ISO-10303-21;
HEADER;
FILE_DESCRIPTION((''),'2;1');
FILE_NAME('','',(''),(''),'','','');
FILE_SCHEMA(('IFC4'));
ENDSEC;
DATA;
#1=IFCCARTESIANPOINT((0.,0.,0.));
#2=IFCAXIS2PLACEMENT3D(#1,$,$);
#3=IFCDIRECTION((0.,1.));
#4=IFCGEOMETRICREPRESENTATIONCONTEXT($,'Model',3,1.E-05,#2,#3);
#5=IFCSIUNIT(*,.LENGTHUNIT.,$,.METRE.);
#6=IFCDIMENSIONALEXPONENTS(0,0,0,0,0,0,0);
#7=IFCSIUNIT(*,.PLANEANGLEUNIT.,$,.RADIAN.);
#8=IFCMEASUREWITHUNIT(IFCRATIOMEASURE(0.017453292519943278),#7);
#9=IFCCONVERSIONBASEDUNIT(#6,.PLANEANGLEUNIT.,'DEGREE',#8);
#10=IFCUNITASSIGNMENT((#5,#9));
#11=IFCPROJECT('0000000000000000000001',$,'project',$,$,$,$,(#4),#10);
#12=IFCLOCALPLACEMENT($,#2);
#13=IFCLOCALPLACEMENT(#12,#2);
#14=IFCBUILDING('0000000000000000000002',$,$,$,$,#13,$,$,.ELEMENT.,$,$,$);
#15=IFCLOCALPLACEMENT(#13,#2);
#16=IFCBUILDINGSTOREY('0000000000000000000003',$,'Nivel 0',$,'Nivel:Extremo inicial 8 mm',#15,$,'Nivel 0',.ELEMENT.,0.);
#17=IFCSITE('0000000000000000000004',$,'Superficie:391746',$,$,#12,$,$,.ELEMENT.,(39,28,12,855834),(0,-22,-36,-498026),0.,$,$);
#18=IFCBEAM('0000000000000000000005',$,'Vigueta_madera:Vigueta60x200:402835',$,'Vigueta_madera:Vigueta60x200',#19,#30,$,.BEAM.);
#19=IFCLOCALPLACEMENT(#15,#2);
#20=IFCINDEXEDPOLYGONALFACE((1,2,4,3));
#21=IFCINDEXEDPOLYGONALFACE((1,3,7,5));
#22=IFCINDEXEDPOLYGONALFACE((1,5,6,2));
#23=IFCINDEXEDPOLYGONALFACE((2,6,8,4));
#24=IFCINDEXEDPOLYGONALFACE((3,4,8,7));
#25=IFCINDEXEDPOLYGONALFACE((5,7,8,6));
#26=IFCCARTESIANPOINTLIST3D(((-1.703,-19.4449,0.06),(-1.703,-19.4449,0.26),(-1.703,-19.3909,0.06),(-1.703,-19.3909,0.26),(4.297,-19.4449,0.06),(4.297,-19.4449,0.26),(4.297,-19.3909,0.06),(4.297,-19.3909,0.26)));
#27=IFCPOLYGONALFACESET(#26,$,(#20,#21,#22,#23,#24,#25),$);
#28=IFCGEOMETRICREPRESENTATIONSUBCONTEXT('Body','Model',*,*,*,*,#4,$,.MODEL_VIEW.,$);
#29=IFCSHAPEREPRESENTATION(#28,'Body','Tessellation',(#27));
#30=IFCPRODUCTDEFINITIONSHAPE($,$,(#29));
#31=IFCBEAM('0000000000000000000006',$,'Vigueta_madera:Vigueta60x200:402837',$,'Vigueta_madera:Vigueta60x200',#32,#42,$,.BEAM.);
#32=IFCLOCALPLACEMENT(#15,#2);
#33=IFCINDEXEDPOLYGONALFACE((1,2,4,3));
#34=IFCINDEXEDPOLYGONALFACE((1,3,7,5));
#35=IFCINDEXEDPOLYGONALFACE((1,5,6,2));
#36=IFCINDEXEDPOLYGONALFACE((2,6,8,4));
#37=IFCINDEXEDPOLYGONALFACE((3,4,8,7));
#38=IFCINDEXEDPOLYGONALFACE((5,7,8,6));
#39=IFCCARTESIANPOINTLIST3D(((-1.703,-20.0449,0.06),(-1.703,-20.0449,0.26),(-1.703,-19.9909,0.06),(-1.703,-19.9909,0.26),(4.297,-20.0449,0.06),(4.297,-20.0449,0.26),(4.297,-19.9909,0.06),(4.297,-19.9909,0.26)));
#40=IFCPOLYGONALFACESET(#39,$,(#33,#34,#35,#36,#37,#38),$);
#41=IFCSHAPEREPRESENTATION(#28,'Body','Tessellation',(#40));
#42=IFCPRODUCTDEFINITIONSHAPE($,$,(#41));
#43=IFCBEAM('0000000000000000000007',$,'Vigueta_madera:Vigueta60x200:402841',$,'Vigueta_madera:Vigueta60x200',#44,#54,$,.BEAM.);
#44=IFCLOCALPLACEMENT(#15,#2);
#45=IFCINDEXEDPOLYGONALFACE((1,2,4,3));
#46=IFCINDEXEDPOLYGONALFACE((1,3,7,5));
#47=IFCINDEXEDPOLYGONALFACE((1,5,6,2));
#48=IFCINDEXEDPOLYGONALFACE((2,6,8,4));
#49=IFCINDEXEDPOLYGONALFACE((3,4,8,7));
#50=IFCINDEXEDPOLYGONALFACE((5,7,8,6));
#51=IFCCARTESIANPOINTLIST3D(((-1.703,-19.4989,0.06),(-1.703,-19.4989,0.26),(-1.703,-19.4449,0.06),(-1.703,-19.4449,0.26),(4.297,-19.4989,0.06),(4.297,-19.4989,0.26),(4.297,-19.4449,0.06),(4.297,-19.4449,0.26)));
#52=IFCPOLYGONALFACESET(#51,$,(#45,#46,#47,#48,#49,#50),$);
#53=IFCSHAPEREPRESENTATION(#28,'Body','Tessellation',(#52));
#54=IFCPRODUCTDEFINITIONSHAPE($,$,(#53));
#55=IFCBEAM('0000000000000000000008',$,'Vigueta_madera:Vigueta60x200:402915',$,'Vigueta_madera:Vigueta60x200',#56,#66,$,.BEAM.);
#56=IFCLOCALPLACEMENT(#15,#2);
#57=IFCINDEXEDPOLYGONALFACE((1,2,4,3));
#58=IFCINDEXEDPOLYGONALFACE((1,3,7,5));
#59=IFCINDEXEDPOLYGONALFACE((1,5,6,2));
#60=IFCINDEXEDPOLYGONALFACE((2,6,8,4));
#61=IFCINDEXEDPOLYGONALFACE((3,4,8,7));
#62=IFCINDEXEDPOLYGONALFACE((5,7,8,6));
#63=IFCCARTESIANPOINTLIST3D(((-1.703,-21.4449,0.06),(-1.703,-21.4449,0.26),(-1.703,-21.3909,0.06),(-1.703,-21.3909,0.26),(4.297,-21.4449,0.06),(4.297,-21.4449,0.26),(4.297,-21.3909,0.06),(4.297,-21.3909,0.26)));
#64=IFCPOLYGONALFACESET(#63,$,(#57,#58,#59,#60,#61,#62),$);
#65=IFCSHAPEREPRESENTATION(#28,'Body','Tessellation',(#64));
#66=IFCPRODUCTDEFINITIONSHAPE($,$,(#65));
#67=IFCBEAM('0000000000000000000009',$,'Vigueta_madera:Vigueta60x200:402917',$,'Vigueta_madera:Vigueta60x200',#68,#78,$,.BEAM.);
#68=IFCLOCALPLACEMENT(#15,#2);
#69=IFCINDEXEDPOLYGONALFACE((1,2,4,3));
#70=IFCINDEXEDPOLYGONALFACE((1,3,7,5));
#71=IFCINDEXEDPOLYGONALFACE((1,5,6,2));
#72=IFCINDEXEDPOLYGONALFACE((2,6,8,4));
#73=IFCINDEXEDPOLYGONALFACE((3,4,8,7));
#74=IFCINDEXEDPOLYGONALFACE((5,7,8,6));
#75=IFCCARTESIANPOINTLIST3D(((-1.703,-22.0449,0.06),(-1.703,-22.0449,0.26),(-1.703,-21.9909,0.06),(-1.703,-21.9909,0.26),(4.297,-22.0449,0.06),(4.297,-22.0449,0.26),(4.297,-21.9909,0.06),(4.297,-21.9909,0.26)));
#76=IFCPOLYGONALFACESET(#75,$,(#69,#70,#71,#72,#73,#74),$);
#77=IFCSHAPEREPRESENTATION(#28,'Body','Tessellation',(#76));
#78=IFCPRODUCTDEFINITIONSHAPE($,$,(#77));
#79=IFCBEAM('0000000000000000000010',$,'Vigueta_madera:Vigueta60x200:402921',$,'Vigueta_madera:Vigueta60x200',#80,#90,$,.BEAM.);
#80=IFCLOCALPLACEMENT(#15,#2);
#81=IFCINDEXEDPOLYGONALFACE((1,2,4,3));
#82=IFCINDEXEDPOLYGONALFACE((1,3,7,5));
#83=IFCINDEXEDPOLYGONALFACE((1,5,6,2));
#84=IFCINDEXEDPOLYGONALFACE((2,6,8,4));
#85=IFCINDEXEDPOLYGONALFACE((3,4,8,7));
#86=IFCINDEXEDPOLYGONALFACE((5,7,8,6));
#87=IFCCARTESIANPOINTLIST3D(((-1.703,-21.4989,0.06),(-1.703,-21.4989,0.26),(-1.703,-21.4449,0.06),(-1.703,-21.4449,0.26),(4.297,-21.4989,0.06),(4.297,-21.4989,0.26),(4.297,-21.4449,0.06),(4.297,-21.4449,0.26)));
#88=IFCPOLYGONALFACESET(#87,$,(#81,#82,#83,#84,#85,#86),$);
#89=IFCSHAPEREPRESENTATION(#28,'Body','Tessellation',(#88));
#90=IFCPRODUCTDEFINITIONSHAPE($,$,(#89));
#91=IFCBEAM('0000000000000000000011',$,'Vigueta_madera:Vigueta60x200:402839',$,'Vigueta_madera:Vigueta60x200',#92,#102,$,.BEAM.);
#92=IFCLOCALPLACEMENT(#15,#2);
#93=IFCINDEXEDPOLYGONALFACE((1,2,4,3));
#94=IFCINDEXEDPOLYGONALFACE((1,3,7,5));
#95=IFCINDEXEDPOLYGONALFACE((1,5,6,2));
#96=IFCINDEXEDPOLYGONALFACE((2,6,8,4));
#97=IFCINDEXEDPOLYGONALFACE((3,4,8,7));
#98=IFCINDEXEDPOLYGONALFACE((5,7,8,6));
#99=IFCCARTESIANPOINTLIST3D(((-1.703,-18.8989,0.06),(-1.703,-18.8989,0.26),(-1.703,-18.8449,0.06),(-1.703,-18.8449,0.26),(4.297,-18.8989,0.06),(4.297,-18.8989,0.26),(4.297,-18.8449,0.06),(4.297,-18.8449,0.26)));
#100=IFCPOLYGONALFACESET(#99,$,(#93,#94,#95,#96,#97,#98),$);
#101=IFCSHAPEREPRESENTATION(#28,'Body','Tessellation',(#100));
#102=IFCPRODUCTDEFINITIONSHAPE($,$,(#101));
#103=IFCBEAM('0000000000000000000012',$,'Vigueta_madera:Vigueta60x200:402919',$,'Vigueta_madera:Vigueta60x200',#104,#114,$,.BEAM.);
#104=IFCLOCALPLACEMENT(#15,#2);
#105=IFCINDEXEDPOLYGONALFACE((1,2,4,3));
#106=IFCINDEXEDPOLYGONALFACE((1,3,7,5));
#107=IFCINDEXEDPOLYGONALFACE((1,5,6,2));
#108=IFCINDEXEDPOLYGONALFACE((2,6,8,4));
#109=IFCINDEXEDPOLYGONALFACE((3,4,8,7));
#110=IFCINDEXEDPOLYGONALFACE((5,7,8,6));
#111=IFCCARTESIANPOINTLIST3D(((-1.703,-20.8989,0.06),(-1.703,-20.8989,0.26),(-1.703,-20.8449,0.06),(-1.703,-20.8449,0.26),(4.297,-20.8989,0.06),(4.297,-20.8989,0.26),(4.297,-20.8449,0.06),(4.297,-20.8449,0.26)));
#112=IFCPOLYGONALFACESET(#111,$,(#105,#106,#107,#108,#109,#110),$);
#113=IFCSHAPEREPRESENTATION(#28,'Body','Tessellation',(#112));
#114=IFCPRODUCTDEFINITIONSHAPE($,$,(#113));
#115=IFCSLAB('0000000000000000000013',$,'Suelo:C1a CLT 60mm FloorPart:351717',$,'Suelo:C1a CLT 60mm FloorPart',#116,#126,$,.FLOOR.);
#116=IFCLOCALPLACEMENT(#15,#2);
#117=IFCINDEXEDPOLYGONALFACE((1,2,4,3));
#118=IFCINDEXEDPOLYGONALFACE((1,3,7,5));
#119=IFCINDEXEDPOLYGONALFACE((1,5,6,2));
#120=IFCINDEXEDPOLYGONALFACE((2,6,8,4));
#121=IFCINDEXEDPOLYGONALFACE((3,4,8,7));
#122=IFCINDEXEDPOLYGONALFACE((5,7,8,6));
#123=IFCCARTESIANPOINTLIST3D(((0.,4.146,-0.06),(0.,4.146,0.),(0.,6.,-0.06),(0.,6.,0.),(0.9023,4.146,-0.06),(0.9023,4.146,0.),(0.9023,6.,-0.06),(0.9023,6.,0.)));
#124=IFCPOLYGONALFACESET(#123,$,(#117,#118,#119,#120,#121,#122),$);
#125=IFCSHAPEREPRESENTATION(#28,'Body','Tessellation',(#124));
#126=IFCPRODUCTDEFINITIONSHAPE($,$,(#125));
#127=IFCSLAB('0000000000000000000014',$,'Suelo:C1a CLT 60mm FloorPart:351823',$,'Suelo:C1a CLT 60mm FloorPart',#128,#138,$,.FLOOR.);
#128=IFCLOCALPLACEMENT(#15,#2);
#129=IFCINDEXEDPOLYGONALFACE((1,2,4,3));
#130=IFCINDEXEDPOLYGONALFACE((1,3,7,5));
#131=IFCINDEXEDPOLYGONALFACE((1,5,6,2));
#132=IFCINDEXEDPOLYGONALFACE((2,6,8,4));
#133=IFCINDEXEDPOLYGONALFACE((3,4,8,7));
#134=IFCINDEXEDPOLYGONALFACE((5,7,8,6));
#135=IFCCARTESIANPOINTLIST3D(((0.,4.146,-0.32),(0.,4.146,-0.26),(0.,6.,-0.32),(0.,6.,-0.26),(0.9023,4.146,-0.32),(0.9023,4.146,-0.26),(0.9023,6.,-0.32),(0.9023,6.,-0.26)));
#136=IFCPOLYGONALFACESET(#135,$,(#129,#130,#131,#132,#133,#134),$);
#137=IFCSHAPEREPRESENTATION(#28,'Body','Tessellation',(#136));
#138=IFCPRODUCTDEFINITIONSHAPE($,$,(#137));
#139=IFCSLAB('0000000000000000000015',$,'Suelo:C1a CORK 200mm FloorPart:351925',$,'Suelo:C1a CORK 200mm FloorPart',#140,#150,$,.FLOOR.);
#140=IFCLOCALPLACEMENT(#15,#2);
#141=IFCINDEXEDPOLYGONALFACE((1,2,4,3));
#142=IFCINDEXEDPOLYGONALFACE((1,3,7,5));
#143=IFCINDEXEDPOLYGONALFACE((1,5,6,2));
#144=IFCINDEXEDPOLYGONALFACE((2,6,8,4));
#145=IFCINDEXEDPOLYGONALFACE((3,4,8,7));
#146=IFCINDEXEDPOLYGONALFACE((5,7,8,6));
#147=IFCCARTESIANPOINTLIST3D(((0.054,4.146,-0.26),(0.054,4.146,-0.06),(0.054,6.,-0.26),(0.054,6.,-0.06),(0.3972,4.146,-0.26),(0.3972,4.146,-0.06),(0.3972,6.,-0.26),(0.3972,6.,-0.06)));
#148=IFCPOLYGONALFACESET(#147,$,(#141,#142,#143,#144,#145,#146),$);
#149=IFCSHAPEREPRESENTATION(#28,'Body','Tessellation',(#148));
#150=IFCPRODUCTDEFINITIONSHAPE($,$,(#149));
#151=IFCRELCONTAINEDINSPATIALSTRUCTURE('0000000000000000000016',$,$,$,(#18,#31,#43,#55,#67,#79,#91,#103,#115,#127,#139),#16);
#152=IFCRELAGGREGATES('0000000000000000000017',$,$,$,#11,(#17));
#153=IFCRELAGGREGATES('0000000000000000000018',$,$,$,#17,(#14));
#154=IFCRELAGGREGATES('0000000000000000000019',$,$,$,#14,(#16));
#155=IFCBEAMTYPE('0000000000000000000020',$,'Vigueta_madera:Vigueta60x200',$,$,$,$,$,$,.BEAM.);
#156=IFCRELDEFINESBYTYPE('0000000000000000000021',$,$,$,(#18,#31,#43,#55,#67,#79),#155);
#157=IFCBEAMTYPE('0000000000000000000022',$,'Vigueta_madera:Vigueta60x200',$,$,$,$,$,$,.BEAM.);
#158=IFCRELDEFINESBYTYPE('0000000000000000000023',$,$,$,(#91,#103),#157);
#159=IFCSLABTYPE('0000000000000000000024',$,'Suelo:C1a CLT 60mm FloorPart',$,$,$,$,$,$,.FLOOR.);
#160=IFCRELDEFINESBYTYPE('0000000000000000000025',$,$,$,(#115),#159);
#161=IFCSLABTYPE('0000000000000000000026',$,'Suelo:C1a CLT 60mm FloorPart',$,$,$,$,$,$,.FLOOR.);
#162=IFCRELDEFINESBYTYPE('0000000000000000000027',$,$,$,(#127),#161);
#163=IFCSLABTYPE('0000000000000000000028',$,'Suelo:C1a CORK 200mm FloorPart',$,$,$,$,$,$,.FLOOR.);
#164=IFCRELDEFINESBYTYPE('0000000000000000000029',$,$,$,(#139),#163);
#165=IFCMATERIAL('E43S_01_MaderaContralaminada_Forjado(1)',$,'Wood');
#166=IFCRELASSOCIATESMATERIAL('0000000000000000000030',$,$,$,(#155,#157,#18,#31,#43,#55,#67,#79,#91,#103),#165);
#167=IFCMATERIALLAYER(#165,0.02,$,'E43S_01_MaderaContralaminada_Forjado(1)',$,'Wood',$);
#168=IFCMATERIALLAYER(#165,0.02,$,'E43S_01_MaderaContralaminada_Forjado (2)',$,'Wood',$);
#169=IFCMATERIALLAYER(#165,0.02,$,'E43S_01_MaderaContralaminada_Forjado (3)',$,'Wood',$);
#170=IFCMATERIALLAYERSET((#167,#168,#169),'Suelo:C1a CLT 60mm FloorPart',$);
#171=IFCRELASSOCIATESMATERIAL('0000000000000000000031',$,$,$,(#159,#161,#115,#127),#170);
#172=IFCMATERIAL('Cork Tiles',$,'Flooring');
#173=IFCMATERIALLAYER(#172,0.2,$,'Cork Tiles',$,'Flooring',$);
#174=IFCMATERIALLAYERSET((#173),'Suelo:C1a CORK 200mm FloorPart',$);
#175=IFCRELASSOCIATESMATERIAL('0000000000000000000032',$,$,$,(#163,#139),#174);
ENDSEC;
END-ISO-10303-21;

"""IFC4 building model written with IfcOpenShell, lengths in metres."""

from ifc_helpers import new_model, entity, si_unit, converted_unit, direction, frame, frame_2d, origin, origin_2d_with_axis, place, context, subcontext, project, spatial, polyline, segment, composite_curve, rectangle, outline, extrude, source, transform, mapped, material, layer, layer_set, layer_usage, material_profile, profile_set, profile_usage, type_object, type_shapes, element, save


model = new_model("IFC4")

# Units and contexts
model_context = context("Model", 3, precision=1e-05, world=origin(), true_north=direction((0.0, 1.0)))
body_context = subcontext(model_context, "Body", "Model", "MODEL_VIEW")
ifc_project = project(units=[si_unit("LENGTHUNIT", "METRE"), converted_unit("PLANEANGLEUNIT", "DEGREE", entity("IfcRatioMeasure", 0.017453292519943278), si_unit("PLANEANGLEUNIT", "RADIAN"), dimensions=[0, 0, 0, 0, 0, 0, 0])], contexts=[model_context])

# Site, building, storey
site_placement = place(None, origin())
site = spatial("IfcSite", under=ifc_project, at=site_placement, Name="Superficie:391746", CompositionType="ELEMENT", RefLatitude=(39, 28, 12, 855834), RefLongitude=(0, -22, -36, -498026), RefElevation=0.0)
building_placement = place(site_placement, origin())
building = spatial("IfcBuilding", under=site, at=building_placement, CompositionType="ELEMENT")
storey_placement = place(building_placement, origin())
storey = spatial("IfcBuildingStorey", under=building, at=storey_placement, Name="Nivel 0", ObjectType="Nivel:Extremo inicial 8 mm", LongName="Nivel 0", CompositionType="ELEMENT", Elevation=0.0)

# Beams
ifc_material_1 = material(Name="E43S_01_MaderaContralaminada_Forjado(1)", Category="Wood")
ifc_material_profile_1 = material_profile(ifc_material_1, outline(composite_curve([segment(polyline([(-0.027, -0.1, 0.0), (-0.027, 0.1, 0.0)]), True, "CONTINUOUS"), segment(polyline([(-0.027, 0.1, 0.0), (0.027, 0.1, 0.0)]), True, "CONTINUOUS"), segment(polyline([(0.027, 0.1, 0.0), (0.027, -0.1, 0.0)]), True, "CONTINUOUS"), segment(polyline([(0.027, -0.1, 0.0), (-0.027, -0.1, 0.0)]), True, "CONTINUOUS")], self_intersect=False), kind="CURVE"), Name="Vigueta60x200")
ifc_material_profile_2 = material_profile(ifc_material_1, outline(composite_curve([segment(polyline([(0.927, -0.027, -0.1), (0.927, -0.027, 0.1)]), True, "CONTINUOUS"), segment(polyline([(0.927, -0.027, 0.1), (-0.927, -0.027, 0.1)]), True, "CONTINUOUS"), segment(polyline([(-0.927, -0.027, 0.1), (-0.927, -0.027, -0.1)]), True, "CONTINUOUS"), segment(polyline([(-0.927, -0.027, -0.1), (0.927, -0.027, -0.1)]), True, "CONTINUOUS")], self_intersect=False), kind="CURVE"), Name="Vigueta60x200")
ifc_profile_set = profile_set([ifc_material_profile_1, ifc_material_profile_2], Name="Vigueta60x200")
ifc_profile_usage_1 = profile_usage(ifc_profile_set, cardinal=8)
beam_type_1 = type_object("IfcBeamType", Name="Vigueta_madera:Vigueta60x200", PredefinedType="BEAM", material=ifc_profile_set)
shared_shape_1 = source(origin(), body_context, "Body", "SweptSolid", [
    extrude(rectangle(XDim=0.2, YDim=0.054, at=origin_2d_with_axis()), frame((-3.0, 0.0, 0.0), z_axis=(1.0, 0.0, 0.0), x_axis=(0.0, 0.0, -1.0)), (0.0, 0.0, 1.0), 6.0),
])
type_shapes(beam_type_1, [shared_shape_1])
beam_1_placement = place(storey_placement, frame((1.297, -19.4179, 0.16), z_axis=(0.0, 0.0, 1.0), x_axis=(-1.0, 0.0, 0.0)))
element("IfcBeam", 1, at=beam_1_placement, inside=storey, type_object=beam_type_1, material=ifc_profile_usage_1, Name="Vigueta_madera:Vigueta60x200:402835", ObjectType="Vigueta_madera:Vigueta60x200", PredefinedType="BEAM", context=body_context, shape_type="MappedRepresentation", body=[
    mapped(shared_shape_1, transform((0.0, 0.0, 0.0), scale=1.0)),
])
ifc_profile_usage_2 = profile_usage(ifc_profile_set, cardinal=8)
beam_2_placement = place(storey_placement, frame((1.297, -20.0179, 0.16), z_axis=(0.0, 0.0, 1.0), x_axis=(-1.0, 0.0, 0.0)))
element("IfcBeam", 2, at=beam_2_placement, inside=storey, type_object=beam_type_1, material=ifc_profile_usage_2, Name="Vigueta_madera:Vigueta60x200:402837", ObjectType="Vigueta_madera:Vigueta60x200", PredefinedType="BEAM", context=body_context, shape_type="MappedRepresentation", body=[
    mapped(shared_shape_1, transform((0.0, 0.0, 0.0), scale=1.0)),
])
ifc_profile_usage_3 = profile_usage(ifc_profile_set, cardinal=8)
beam_3_placement = place(storey_placement, frame((1.297, -19.4719, 0.16), z_axis=(0.0, 0.0, 1.0), x_axis=(-1.0, 0.0, 0.0)))
element("IfcBeam", 3, at=beam_3_placement, inside=storey, type_object=beam_type_1, material=ifc_profile_usage_3, Name="Vigueta_madera:Vigueta60x200:402841", ObjectType="Vigueta_madera:Vigueta60x200", PredefinedType="BEAM", context=body_context, shape_type="MappedRepresentation", body=[
    mapped(shared_shape_1, transform((0.0, 0.0, 0.0), scale=1.0)),
])
ifc_profile_usage_4 = profile_usage(ifc_profile_set, cardinal=8)
beam_4_placement = place(storey_placement, frame((1.297, -21.4179, 0.16), z_axis=(0.0, 0.0, 1.0), x_axis=(-1.0, 0.0, 0.0)))
element("IfcBeam", 4, at=beam_4_placement, inside=storey, type_object=beam_type_1, material=ifc_profile_usage_4, Name="Vigueta_madera:Vigueta60x200:402915", ObjectType="Vigueta_madera:Vigueta60x200", PredefinedType="BEAM", context=body_context, shape_type="MappedRepresentation", body=[
    mapped(shared_shape_1, transform((0.0, 0.0, 0.0), scale=1.0)),
])
ifc_profile_usage_5 = profile_usage(ifc_profile_set, cardinal=8)
beam_5_placement = place(storey_placement, frame((1.297, -22.0179, 0.16), z_axis=(0.0, 0.0, 1.0), x_axis=(-1.0, 0.0, 0.0)))
element("IfcBeam", 5, at=beam_5_placement, inside=storey, type_object=beam_type_1, material=ifc_profile_usage_5, Name="Vigueta_madera:Vigueta60x200:402917", ObjectType="Vigueta_madera:Vigueta60x200", PredefinedType="BEAM", context=body_context, shape_type="MappedRepresentation", body=[
    mapped(shared_shape_1, transform((0.0, 0.0, 0.0), scale=1.0)),
])
ifc_profile_usage_6 = profile_usage(ifc_profile_set, cardinal=8)
beam_6_placement = place(storey_placement, frame((1.297, -21.4719, 0.16), z_axis=(0.0, 0.0, 1.0), x_axis=(-1.0, 0.0, 0.0)))
element("IfcBeam", 6, at=beam_6_placement, inside=storey, type_object=beam_type_1, material=ifc_profile_usage_6, Name="Vigueta_madera:Vigueta60x200:402921", ObjectType="Vigueta_madera:Vigueta60x200", PredefinedType="BEAM", context=body_context, shape_type="MappedRepresentation", body=[
    mapped(shared_shape_1, transform((0.0, 0.0, 0.0), scale=1.0)),
])
ifc_profile_usage_7 = profile_usage(ifc_profile_set, cardinal=8)
beam_type_2 = type_object("IfcBeamType", Name="Vigueta_madera:Vigueta60x200", PredefinedType="BEAM", material=ifc_profile_set)
shared_shape_2 = source(origin(), body_context, "Body", "SweptSolid", [
    extrude(rectangle(XDim=0.2, YDim=0.054, at=origin_2d_with_axis()), frame((-3.06, 0.0, 0.0), z_axis=(1.0, 0.0, 0.0), x_axis=(0.0, 0.0, -1.0)), (0.0, 0.0, 1.0), 6.0),
])
type_shapes(beam_type_2, [shared_shape_2])
beam_7_placement = place(storey_placement, frame((1.237, -18.8719, 0.16), z_axis=(0.0, 0.0, 1.0), x_axis=(-1.0, 0.0, 0.0)))
element("IfcBeam", 7, at=beam_7_placement, inside=storey, type_object=beam_type_2, material=ifc_profile_usage_7, Name="Vigueta_madera:Vigueta60x200:402839", ObjectType="Vigueta_madera:Vigueta60x200", PredefinedType="BEAM", context=body_context, shape_type="MappedRepresentation", body=[
    mapped(shared_shape_2, transform((0.0, 0.0, 0.0), scale=1.0)),
])
ifc_profile_usage_8 = profile_usage(ifc_profile_set, cardinal=8)
beam_8_placement = place(storey_placement, frame((1.237, -20.8719, 0.16), z_axis=(0.0, 0.0, 1.0), x_axis=(-1.0, 0.0, 0.0)))
element("IfcBeam", 8, at=beam_8_placement, inside=storey, type_object=beam_type_2, material=ifc_profile_usage_8, Name="Vigueta_madera:Vigueta60x200:402919", ObjectType="Vigueta_madera:Vigueta60x200", PredefinedType="BEAM", context=body_context, shape_type="MappedRepresentation", body=[
    mapped(shared_shape_2, transform((0.0, 0.0, 0.0), scale=1.0)),
])

# Slabs
ifc_layer_1 = layer(ifc_material_1, 0.02, Name="E43S_01_MaderaContralaminada_Forjado(1)", Category="Wood")
ifc_layer_2 = layer(ifc_material_1, 0.02, Name="E43S_01_MaderaContralaminada_Forjado (2)", Category="Wood")
ifc_layer_3 = layer(ifc_material_1, 0.02, Name="E43S_01_MaderaContralaminada_Forjado (3)", Category="Wood")
ifc_layer_set_1 = layer_set([ifc_layer_1, ifc_layer_2, ifc_layer_3], Name="Suelo:C1a CLT 60mm FloorPart")
ifc_layer_usage_1 = layer_usage(ifc_layer_set_1, "AXIS3", "POSITIVE", 0.0)
slab_type_1 = type_object("IfcSlabType", Name="Suelo:C1a CLT 60mm FloorPart", PredefinedType="FLOOR", material=ifc_layer_set_1)
slab_1_placement = place(storey_placement, origin())
element("IfcSlab", 9, at=slab_1_placement, inside=storey, type_object=slab_type_1, material=ifc_layer_usage_1, Name="Suelo:C1a CLT 60mm FloorPart:351717", ObjectType="Suelo:C1a CLT 60mm FloorPart", PredefinedType="FLOOR", context=body_context, shape_type="SweptSolid", body=[
    extrude(rectangle(XDim=1.854, YDim=0.9023, at=frame_2d((0.0, 0.0), x_axis=(1.0, 0.0))), frame((0.4512, 5.073, 0.0), z_axis=(0.0, 0.0, -1.0), x_axis=(0.0, 1.0, 0.0)), (0.0, 0.0, 1.0), 0.06),
])
ifc_layer_usage_2 = layer_usage(ifc_layer_set_1, "AXIS3", "POSITIVE", 0.0)
slab_type_2 = type_object("IfcSlabType", Name="Suelo:C1a CLT 60mm FloorPart", PredefinedType="FLOOR", material=ifc_layer_set_1)
slab_2_placement = place(storey_placement, origin())
element("IfcSlab", 10, at=slab_2_placement, inside=storey, type_object=slab_type_2, material=ifc_layer_usage_2, Name="Suelo:C1a CLT 60mm FloorPart:351823", ObjectType="Suelo:C1a CLT 60mm FloorPart", PredefinedType="FLOOR", context=body_context, shape_type="SweptSolid", body=[
    extrude(rectangle(XDim=1.854, YDim=0.9023, at=frame_2d((0.0, 0.0), x_axis=(1.0, 0.0))), frame((0.4512, 5.073, -0.26), z_axis=(0.0, 0.0, -1.0), x_axis=(0.0, 1.0, 0.0)), (0.0, 0.0, 1.0), 0.06),
])
ifc_material_2 = material(Name="Cork Tiles", Category="Flooring")
ifc_layer_4 = layer(ifc_material_2, 0.2, Name="Cork Tiles", Category="Flooring")
ifc_layer_set_2 = layer_set([ifc_layer_4], Name="Suelo:C1a CORK 200mm FloorPart")
ifc_layer_usage_3 = layer_usage(ifc_layer_set_2, "AXIS3", "POSITIVE", 0.0)
slab_type_3 = type_object("IfcSlabType", Name="Suelo:C1a CORK 200mm FloorPart", PredefinedType="FLOOR", material=ifc_layer_set_2)
slab_3_placement = place(storey_placement, origin())
element("IfcSlab", 11, at=slab_3_placement, inside=storey, type_object=slab_type_3, material=ifc_layer_usage_3, Name="Suelo:C1a CORK 200mm FloorPart:351925", ObjectType="Suelo:C1a CORK 200mm FloorPart", PredefinedType="FLOOR", context=body_context, shape_type="SweptSolid", body=[
    extrude(rectangle(XDim=1.854, YDim=0.3432, at=frame_2d((0.0, 0.0), x_axis=(1.0, 0.0))), frame((0.2256, 5.073, -0.06), z_axis=(0.0, 0.0, -1.0), x_axis=(0.0, 1.0, 0.0)), (0.0, 0.0, 1.0), 0.2),
])

save(model, "model.ifc")
